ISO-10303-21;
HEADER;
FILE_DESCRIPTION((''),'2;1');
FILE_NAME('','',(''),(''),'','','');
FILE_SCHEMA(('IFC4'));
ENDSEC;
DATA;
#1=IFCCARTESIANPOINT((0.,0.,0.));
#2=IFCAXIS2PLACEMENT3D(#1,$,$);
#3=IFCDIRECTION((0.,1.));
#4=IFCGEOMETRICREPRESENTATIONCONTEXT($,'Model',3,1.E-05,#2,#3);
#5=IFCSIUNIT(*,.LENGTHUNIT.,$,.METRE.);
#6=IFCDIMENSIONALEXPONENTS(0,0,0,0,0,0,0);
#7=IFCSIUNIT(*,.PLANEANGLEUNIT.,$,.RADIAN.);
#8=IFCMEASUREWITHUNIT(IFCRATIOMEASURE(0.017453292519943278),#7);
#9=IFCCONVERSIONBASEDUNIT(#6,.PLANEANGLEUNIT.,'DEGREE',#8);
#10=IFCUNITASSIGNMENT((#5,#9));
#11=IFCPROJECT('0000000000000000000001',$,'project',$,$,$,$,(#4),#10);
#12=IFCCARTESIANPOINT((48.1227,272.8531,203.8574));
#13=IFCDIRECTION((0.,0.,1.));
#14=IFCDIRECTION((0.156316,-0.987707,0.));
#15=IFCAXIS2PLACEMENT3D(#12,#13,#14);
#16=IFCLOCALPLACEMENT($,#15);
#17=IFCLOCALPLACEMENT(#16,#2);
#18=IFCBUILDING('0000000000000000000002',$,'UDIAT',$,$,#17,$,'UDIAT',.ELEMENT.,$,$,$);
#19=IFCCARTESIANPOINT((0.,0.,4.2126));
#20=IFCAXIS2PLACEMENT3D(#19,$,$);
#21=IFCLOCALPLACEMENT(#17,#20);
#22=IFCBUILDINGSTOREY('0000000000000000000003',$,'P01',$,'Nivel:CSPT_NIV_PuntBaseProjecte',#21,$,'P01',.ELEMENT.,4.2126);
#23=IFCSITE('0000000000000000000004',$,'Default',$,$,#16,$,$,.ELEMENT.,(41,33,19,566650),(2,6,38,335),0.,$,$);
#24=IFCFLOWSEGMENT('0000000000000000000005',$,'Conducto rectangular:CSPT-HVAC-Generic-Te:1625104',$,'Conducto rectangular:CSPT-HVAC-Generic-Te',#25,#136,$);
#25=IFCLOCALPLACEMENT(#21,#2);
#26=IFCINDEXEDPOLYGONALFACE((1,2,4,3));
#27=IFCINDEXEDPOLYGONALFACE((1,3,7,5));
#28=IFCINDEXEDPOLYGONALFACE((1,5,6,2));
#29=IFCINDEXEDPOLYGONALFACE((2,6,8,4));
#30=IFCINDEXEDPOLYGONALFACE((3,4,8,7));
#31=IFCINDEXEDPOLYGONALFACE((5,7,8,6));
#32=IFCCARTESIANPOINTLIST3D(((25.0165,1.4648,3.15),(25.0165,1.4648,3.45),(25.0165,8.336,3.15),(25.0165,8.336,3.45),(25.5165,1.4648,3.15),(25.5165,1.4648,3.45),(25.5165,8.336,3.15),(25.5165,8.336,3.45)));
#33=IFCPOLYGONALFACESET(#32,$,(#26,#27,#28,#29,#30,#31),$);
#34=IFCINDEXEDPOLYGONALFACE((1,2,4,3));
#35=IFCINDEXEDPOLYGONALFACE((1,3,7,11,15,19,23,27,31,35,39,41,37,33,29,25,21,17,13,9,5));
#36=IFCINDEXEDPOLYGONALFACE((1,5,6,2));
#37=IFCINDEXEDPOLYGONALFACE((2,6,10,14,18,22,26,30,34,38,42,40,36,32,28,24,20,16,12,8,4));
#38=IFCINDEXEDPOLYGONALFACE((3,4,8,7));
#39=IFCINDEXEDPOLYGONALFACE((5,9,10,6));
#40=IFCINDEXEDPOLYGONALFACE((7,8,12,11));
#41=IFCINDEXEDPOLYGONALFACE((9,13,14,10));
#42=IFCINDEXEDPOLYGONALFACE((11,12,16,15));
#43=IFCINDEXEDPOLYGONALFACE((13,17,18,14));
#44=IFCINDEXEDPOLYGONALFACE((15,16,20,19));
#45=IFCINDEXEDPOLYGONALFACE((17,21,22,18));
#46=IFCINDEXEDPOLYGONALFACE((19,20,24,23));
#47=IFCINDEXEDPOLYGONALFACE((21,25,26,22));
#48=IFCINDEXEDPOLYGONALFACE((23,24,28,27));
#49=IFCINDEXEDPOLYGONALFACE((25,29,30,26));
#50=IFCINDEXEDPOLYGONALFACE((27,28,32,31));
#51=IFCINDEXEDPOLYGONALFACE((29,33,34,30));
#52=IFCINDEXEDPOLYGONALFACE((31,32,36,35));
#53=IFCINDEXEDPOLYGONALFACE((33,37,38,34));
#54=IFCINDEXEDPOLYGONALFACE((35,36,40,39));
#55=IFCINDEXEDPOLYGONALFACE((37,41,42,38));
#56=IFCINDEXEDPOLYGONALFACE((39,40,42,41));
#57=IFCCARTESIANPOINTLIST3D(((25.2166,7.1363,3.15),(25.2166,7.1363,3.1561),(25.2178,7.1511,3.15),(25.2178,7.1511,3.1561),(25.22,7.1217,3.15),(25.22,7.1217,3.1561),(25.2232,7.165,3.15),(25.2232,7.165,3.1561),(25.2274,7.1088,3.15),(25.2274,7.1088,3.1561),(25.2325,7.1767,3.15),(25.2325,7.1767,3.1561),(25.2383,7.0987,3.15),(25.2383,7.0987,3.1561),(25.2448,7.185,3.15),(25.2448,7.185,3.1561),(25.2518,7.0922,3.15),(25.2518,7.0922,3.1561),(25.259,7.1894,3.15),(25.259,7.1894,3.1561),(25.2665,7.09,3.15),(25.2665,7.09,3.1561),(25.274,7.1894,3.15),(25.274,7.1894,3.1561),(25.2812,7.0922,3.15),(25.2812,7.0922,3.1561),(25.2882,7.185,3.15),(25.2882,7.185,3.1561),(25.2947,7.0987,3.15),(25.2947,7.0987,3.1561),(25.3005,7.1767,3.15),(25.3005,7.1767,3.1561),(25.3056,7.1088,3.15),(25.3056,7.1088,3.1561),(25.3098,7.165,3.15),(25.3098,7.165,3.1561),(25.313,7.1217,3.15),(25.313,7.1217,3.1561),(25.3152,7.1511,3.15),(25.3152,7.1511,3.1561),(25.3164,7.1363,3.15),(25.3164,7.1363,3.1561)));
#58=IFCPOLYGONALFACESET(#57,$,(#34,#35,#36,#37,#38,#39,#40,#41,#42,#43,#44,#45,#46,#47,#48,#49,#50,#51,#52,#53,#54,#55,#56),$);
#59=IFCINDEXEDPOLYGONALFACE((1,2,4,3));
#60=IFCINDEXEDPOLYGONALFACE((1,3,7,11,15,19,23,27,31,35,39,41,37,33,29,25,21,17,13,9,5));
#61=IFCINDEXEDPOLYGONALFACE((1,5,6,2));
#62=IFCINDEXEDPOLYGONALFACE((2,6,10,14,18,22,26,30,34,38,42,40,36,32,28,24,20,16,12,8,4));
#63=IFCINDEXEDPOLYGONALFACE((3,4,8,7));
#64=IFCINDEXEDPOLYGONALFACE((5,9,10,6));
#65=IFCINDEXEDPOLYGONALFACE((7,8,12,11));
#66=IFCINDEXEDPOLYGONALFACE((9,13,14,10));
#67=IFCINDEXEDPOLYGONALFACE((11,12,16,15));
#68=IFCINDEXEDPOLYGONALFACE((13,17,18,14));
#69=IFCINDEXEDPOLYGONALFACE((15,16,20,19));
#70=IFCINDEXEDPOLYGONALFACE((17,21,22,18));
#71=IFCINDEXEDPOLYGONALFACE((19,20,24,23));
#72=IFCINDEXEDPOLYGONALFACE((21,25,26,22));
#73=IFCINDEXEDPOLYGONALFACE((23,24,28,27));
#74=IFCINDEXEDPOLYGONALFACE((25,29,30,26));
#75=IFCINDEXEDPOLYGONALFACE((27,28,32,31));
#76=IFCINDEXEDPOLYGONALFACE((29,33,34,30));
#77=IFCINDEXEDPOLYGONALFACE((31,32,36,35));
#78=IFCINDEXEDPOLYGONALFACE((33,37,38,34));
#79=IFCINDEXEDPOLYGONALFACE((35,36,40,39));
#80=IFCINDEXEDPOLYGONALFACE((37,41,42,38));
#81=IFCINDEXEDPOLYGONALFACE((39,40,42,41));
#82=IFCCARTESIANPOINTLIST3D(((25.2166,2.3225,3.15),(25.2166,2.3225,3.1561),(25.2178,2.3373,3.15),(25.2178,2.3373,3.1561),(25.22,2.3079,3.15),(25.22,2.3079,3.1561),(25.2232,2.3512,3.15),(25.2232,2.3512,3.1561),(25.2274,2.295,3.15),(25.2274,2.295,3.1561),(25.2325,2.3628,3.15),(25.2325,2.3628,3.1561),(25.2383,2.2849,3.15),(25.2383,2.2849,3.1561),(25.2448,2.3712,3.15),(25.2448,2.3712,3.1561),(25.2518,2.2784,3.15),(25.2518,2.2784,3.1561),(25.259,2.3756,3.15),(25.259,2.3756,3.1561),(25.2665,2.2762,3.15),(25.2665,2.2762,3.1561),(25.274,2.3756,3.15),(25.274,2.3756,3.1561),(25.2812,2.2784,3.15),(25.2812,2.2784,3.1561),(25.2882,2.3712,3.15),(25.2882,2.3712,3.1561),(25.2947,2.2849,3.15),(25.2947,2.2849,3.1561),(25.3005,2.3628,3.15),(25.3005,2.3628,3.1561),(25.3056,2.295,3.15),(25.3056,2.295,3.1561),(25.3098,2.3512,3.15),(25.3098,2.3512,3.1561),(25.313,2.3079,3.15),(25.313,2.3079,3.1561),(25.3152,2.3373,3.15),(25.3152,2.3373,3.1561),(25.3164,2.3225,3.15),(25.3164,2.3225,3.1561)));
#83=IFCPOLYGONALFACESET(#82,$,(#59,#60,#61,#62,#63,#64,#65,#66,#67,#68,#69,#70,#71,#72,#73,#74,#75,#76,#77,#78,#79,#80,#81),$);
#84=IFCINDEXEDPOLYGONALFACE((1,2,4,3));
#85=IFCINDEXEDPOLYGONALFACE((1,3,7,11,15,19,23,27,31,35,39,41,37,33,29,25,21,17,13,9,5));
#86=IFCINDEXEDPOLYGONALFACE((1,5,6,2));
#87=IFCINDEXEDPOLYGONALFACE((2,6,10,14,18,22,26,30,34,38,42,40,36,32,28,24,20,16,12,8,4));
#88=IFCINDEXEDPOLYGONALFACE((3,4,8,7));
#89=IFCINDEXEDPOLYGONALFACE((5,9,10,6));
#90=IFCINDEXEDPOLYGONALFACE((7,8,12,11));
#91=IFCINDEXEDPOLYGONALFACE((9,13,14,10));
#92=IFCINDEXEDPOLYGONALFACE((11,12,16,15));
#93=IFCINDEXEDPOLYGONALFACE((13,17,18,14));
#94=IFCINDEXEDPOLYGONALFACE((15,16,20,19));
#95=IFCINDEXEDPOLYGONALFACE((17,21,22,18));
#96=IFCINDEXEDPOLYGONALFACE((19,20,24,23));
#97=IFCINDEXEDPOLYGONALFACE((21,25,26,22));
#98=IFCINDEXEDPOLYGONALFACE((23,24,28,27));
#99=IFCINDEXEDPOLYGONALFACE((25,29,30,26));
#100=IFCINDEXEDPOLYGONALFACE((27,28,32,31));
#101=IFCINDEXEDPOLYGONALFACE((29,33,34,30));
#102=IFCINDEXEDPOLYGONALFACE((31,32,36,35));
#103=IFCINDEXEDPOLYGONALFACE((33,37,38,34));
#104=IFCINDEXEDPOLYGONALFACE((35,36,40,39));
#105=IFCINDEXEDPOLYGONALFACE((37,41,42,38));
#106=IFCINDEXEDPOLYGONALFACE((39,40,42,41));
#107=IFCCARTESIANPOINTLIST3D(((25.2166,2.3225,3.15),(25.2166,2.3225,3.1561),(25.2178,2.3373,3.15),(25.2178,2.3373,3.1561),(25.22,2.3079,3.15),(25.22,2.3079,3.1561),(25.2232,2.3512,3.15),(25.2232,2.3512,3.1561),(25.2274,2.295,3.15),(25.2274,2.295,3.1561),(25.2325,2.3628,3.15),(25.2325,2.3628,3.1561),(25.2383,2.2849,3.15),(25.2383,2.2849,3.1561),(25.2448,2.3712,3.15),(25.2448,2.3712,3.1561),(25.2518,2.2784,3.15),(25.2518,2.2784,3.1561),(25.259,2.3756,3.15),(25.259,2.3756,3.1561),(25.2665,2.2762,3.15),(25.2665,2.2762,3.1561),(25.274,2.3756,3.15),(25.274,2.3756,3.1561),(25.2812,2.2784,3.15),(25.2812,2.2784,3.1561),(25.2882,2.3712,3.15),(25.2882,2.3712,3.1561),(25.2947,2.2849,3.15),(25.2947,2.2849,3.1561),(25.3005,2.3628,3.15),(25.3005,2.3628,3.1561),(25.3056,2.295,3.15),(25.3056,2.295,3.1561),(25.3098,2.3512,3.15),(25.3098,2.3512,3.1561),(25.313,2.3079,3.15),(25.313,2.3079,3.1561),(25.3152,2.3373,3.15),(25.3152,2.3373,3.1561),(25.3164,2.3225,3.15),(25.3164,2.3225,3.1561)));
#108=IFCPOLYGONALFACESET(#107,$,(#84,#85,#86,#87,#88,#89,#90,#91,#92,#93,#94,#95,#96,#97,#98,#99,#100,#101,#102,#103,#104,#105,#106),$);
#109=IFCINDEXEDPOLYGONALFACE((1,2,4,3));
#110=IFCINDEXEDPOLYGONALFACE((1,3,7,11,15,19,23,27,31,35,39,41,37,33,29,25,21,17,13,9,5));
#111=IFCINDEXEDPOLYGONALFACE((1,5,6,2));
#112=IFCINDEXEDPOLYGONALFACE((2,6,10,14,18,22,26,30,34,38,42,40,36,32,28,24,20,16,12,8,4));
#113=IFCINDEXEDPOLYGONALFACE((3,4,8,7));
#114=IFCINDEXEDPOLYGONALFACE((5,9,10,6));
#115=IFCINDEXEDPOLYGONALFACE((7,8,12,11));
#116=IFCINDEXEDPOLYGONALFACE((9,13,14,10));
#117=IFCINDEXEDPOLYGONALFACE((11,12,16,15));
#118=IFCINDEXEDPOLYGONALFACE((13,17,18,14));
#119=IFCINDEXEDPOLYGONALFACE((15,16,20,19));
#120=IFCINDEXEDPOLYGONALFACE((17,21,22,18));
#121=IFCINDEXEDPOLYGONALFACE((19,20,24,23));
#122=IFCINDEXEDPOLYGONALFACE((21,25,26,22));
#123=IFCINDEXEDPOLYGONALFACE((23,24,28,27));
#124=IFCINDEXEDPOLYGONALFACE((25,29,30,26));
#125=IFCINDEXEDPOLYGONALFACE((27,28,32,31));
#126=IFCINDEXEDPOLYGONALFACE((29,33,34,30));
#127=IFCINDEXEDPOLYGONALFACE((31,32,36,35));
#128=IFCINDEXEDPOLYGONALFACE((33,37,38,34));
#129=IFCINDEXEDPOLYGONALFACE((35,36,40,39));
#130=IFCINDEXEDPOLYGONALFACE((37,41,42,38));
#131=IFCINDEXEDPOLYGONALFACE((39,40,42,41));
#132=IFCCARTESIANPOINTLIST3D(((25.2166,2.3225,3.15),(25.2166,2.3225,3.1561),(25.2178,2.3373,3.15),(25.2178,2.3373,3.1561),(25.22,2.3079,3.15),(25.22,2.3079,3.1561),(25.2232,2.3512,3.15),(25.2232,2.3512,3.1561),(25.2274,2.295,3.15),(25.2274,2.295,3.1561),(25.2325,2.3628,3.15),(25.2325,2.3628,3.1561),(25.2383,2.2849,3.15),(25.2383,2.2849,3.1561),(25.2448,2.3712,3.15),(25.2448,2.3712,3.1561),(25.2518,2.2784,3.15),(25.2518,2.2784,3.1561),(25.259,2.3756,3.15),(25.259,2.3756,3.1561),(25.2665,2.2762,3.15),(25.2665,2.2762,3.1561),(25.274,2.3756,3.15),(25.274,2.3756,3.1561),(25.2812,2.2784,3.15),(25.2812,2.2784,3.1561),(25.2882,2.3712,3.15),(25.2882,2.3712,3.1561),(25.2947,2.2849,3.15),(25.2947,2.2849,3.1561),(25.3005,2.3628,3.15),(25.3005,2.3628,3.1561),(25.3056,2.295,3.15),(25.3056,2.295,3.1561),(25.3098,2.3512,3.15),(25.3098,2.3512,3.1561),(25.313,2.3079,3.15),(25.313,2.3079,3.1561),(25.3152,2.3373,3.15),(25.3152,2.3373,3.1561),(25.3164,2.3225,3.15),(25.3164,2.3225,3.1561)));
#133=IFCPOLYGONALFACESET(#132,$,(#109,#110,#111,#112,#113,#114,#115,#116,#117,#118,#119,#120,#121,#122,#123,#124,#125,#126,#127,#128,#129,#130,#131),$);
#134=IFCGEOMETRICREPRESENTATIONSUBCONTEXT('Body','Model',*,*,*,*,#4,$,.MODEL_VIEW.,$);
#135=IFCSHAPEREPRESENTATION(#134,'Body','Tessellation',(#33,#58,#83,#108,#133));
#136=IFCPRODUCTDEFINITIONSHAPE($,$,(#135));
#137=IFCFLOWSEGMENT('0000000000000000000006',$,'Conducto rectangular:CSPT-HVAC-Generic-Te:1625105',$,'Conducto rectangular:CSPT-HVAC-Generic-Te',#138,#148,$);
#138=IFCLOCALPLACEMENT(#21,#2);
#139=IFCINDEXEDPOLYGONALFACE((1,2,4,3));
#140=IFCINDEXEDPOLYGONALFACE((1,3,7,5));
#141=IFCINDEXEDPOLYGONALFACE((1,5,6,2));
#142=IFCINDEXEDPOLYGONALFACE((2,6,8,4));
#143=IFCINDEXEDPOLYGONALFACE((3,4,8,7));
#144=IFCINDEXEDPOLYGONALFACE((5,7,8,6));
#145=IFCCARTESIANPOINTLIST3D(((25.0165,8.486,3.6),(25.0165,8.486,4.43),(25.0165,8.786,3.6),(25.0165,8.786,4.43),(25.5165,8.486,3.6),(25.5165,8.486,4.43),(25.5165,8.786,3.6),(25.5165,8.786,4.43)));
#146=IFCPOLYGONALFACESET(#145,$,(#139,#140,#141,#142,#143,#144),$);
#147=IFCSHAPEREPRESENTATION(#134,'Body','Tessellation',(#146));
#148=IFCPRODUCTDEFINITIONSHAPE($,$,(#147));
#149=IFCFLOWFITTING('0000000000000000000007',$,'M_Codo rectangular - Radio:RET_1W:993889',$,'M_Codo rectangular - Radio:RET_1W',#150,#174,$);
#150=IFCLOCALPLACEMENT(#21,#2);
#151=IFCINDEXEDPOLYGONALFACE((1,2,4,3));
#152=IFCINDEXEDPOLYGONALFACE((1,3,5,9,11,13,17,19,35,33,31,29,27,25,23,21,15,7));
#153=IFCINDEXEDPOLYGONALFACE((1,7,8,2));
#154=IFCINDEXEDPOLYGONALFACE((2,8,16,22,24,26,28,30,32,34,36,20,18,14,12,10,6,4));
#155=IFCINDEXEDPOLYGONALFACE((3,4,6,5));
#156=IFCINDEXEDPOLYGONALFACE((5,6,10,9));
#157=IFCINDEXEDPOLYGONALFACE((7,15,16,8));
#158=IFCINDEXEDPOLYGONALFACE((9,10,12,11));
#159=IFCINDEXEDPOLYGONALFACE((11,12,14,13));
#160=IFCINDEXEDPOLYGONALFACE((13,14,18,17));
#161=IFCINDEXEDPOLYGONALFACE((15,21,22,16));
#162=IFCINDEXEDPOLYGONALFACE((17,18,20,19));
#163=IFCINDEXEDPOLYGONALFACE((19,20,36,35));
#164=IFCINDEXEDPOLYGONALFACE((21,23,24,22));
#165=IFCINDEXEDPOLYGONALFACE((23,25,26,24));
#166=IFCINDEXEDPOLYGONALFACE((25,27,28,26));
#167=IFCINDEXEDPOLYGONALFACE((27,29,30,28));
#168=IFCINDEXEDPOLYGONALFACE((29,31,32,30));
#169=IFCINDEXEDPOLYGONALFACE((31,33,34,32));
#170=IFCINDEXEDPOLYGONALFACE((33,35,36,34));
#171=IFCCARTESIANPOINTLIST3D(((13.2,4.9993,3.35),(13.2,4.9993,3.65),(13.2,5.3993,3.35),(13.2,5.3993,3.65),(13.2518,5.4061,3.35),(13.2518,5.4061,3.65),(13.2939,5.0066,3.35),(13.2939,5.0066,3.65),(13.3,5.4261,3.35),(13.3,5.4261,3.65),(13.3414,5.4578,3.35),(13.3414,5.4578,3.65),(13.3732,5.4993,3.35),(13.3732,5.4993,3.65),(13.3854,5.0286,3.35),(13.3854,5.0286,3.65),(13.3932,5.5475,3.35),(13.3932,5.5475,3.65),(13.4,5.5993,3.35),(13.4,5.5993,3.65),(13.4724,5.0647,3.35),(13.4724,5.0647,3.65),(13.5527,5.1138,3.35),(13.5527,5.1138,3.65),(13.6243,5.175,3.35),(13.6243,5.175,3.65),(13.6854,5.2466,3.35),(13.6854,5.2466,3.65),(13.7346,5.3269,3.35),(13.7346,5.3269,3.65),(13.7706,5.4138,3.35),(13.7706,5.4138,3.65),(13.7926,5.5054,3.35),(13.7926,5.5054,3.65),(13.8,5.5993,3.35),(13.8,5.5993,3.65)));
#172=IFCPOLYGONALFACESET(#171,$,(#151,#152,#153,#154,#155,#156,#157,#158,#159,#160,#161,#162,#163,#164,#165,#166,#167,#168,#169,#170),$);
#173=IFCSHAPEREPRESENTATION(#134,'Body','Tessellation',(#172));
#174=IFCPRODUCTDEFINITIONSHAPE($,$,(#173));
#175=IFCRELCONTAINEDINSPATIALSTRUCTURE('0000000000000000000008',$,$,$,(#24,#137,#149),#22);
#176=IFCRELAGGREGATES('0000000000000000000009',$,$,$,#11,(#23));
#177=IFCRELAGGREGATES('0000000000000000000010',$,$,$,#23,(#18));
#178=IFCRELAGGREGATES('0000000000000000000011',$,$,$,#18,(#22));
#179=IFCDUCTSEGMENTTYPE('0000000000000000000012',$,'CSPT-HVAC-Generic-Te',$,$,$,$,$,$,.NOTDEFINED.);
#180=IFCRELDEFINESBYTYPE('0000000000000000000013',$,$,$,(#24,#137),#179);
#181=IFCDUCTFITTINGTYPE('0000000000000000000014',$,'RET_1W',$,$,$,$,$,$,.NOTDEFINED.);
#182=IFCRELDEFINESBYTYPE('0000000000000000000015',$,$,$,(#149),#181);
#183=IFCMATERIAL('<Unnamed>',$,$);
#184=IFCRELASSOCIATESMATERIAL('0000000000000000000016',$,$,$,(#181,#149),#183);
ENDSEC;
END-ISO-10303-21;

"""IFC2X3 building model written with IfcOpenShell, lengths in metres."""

from ifc_helpers import new_model, entity, si_unit, converted_unit, direction, frame, frame_2d, origin, origin_2d_with_axis, place, context, subcontext, project, spatial, polyline, circle_curve, parameter, trimmed, segment, composite_curve, rectangle, circle, outline, extrude, source, transform, mapped, material, type_object, type_shapes, element, save


model = new_model("IFC2X3")

# Units and contexts
model_context = context("Model", 3, precision=1e-05, world=origin(), true_north=direction((0.0, 1.0)))
body_context = subcontext(model_context, "Body", "Model", "MODEL_VIEW")
ifc_project = project(units=[si_unit("LENGTHUNIT", "METRE"), converted_unit("PLANEANGLEUNIT", "DEGREE", entity("IfcRatioMeasure", 0.017453292519943278), si_unit("PLANEANGLEUNIT", "RADIAN"), dimensions=[0, 0, 0, 0, 0, 0, 0])], contexts=[model_context])

# Site, building, storey
site_placement = place(None, frame((48.1227, 272.8531, 203.8574), z_axis=(0.0, 0.0, 1.0), x_axis=(0.156316, -0.987707, 0.0)))
site = spatial("IfcSite", under=ifc_project, at=site_placement, Name="Default", CompositionType="ELEMENT", RefLatitude=(41, 33, 19, 566650), RefLongitude=(2, 6, 38, 335), RefElevation=0.0)
building_placement = place(site_placement, origin())
building = spatial("IfcBuilding", under=site, at=building_placement, Name="UDIAT", LongName="UDIAT", CompositionType="ELEMENT")
storey_placement = place(building_placement, frame((0.0, 0.0, 4.2126)))
storey = spatial("IfcBuildingStorey", under=building, at=storey_placement, Name="P01", ObjectType="Nivel:CSPT_NIV_PuntBaseProjecte", LongName="P01", CompositionType="ELEMENT", Elevation=4.2126)

# Flow segments
duct_segment_type = type_object("IfcDuctSegmentType", Name="CSPT-HVAC-Generic-Te", PredefinedType="NOTDEFINED")
flow_segment_1_placement = place(storey_placement, origin())
element("IfcFlowSegment", 1, at=flow_segment_1_placement, inside=storey, type_object=duct_segment_type, Name="Conducto rectangular:CSPT-HVAC-Generic-Te:1625104", ObjectType="Conducto rectangular:CSPT-HVAC-Generic-Te", context=body_context, shape_type="SweptSolid", body=[
    extrude(rectangle(XDim=6.8711, YDim=0.5, at=frame_2d((0.0, 0.0), x_axis=(1.0, 0.0))), frame((25.2665, 4.9004, 3.15), z_axis=(0.0, 0.0, 1.0), x_axis=(0.0, 1.0, 0.0)), (0.0, 0.0, 1.0), 0.3),
    extrude(circle(Radius=0.05, at=origin_2d_with_axis()), frame((25.2665, 7.14, 3.15), z_axis=(0.0, 0.0, 1.0), x_axis=(0.0, -1.0, 0.0)), (0.0, 0.0, 1.0), 0.0061),
    extrude(circle(Radius=0.05, at=origin_2d_with_axis()), frame((25.2665, 2.3262, 3.15), z_axis=(0.0, 0.0, 1.0), x_axis=(0.0, -1.0, 0.0)), (0.0, 0.0, 1.0), 0.0061),
    extrude(circle(Radius=0.05, at=frame_2d((0.0, 0.0), x_axis=(1.0, 0.0))), frame((25.2665, 2.3262, 3.15), z_axis=(0.0, 0.0, 1.0), x_axis=(0.0, -1.0, 0.0)), (0.0, 0.0, 1.0), 0.0061),
    extrude(circle(Radius=0.05, at=frame_2d((0.0, 0.0), x_axis=(1.0, 0.0))), frame((25.2665, 2.3262, 3.15), z_axis=(0.0, 0.0, 1.0), x_axis=(0.0, -1.0, 0.0)), (0.0, 0.0, 1.0), 0.0061),
])
flow_segment_2_placement = place(storey_placement, origin())
element("IfcFlowSegment", 2, at=flow_segment_2_placement, inside=storey, type_object=duct_segment_type, Name="Conducto rectangular:CSPT-HVAC-Generic-Te:1625105", ObjectType="Conducto rectangular:CSPT-HVAC-Generic-Te", context=body_context, shape_type="SweptSolid", body=[
    extrude(rectangle(XDim=0.3, YDim=0.5, at=origin_2d_with_axis()), frame((25.2665, 8.636, 3.6), z_axis=(0.0, 0.0, 1.0), x_axis=(0.0, 1.0, 0.0)), (0.0, 0.0, 1.0), 0.83),
])

# Flow fitting
ifc_material_1 = material(Name="<Unnamed>")
duct_fitting_type_1 = type_object("IfcDuctFittingType", Name="RET_1W", PredefinedType="NOTDEFINED", material=ifc_material_1)
shared_shape_1 = source(origin(), body_context, "Body", "SweptSolid", [
    extrude(outline(composite_curve([segment(polyline([(-0.4, -0.2), (0.0, -0.2)]), True, "CONTINUOUS"), segment(trimmed(circle_curve(frame_2d((0.2, -0.2), x_axis=(0.0, 1.0)), 0.2), [parameter(0.0)], [parameter(90.0)], True, "PARAMETER"), False, "CONTINUOUS"), segment(polyline([(0.2, 0.0), (0.2, 0.4)]), True, "CONTINUOUS"), segment(trimmed(circle_curve(frame_2d((0.2, -0.2), x_axis=(0.0, 1.0)), 0.6), [parameter(0.0)], [parameter(90.0)], True, "PARAMETER"), True, "CONTINUOUS")], self_intersect=False)), frame((-0.2, 0.2, -0.15), z_axis=(0.0, 0.0, 1.0), x_axis=(-1.0, 0.0, 0.0)), (0.0, 0.0, 1.0), 0.3),
])
type_shapes(duct_fitting_type_1, [shared_shape_1])
flow_fitting_1_placement = place(storey_placement, frame((13.6, 5.1993, 3.5)))
element("IfcFlowFitting", 3, at=flow_fitting_1_placement, inside=storey, type_object=duct_fitting_type_1, material=ifc_material_1, Name="M_Codo rectangular - Radio:RET_1W:993889", ObjectType="M_Codo rectangular - Radio:RET_1W", context=body_context, shape_type="MappedRepresentation", body=[
    mapped(shared_shape_1, transform((0.0, 0.0, 0.0), scale=1.0)),
])

save(model, "model.ifc")
